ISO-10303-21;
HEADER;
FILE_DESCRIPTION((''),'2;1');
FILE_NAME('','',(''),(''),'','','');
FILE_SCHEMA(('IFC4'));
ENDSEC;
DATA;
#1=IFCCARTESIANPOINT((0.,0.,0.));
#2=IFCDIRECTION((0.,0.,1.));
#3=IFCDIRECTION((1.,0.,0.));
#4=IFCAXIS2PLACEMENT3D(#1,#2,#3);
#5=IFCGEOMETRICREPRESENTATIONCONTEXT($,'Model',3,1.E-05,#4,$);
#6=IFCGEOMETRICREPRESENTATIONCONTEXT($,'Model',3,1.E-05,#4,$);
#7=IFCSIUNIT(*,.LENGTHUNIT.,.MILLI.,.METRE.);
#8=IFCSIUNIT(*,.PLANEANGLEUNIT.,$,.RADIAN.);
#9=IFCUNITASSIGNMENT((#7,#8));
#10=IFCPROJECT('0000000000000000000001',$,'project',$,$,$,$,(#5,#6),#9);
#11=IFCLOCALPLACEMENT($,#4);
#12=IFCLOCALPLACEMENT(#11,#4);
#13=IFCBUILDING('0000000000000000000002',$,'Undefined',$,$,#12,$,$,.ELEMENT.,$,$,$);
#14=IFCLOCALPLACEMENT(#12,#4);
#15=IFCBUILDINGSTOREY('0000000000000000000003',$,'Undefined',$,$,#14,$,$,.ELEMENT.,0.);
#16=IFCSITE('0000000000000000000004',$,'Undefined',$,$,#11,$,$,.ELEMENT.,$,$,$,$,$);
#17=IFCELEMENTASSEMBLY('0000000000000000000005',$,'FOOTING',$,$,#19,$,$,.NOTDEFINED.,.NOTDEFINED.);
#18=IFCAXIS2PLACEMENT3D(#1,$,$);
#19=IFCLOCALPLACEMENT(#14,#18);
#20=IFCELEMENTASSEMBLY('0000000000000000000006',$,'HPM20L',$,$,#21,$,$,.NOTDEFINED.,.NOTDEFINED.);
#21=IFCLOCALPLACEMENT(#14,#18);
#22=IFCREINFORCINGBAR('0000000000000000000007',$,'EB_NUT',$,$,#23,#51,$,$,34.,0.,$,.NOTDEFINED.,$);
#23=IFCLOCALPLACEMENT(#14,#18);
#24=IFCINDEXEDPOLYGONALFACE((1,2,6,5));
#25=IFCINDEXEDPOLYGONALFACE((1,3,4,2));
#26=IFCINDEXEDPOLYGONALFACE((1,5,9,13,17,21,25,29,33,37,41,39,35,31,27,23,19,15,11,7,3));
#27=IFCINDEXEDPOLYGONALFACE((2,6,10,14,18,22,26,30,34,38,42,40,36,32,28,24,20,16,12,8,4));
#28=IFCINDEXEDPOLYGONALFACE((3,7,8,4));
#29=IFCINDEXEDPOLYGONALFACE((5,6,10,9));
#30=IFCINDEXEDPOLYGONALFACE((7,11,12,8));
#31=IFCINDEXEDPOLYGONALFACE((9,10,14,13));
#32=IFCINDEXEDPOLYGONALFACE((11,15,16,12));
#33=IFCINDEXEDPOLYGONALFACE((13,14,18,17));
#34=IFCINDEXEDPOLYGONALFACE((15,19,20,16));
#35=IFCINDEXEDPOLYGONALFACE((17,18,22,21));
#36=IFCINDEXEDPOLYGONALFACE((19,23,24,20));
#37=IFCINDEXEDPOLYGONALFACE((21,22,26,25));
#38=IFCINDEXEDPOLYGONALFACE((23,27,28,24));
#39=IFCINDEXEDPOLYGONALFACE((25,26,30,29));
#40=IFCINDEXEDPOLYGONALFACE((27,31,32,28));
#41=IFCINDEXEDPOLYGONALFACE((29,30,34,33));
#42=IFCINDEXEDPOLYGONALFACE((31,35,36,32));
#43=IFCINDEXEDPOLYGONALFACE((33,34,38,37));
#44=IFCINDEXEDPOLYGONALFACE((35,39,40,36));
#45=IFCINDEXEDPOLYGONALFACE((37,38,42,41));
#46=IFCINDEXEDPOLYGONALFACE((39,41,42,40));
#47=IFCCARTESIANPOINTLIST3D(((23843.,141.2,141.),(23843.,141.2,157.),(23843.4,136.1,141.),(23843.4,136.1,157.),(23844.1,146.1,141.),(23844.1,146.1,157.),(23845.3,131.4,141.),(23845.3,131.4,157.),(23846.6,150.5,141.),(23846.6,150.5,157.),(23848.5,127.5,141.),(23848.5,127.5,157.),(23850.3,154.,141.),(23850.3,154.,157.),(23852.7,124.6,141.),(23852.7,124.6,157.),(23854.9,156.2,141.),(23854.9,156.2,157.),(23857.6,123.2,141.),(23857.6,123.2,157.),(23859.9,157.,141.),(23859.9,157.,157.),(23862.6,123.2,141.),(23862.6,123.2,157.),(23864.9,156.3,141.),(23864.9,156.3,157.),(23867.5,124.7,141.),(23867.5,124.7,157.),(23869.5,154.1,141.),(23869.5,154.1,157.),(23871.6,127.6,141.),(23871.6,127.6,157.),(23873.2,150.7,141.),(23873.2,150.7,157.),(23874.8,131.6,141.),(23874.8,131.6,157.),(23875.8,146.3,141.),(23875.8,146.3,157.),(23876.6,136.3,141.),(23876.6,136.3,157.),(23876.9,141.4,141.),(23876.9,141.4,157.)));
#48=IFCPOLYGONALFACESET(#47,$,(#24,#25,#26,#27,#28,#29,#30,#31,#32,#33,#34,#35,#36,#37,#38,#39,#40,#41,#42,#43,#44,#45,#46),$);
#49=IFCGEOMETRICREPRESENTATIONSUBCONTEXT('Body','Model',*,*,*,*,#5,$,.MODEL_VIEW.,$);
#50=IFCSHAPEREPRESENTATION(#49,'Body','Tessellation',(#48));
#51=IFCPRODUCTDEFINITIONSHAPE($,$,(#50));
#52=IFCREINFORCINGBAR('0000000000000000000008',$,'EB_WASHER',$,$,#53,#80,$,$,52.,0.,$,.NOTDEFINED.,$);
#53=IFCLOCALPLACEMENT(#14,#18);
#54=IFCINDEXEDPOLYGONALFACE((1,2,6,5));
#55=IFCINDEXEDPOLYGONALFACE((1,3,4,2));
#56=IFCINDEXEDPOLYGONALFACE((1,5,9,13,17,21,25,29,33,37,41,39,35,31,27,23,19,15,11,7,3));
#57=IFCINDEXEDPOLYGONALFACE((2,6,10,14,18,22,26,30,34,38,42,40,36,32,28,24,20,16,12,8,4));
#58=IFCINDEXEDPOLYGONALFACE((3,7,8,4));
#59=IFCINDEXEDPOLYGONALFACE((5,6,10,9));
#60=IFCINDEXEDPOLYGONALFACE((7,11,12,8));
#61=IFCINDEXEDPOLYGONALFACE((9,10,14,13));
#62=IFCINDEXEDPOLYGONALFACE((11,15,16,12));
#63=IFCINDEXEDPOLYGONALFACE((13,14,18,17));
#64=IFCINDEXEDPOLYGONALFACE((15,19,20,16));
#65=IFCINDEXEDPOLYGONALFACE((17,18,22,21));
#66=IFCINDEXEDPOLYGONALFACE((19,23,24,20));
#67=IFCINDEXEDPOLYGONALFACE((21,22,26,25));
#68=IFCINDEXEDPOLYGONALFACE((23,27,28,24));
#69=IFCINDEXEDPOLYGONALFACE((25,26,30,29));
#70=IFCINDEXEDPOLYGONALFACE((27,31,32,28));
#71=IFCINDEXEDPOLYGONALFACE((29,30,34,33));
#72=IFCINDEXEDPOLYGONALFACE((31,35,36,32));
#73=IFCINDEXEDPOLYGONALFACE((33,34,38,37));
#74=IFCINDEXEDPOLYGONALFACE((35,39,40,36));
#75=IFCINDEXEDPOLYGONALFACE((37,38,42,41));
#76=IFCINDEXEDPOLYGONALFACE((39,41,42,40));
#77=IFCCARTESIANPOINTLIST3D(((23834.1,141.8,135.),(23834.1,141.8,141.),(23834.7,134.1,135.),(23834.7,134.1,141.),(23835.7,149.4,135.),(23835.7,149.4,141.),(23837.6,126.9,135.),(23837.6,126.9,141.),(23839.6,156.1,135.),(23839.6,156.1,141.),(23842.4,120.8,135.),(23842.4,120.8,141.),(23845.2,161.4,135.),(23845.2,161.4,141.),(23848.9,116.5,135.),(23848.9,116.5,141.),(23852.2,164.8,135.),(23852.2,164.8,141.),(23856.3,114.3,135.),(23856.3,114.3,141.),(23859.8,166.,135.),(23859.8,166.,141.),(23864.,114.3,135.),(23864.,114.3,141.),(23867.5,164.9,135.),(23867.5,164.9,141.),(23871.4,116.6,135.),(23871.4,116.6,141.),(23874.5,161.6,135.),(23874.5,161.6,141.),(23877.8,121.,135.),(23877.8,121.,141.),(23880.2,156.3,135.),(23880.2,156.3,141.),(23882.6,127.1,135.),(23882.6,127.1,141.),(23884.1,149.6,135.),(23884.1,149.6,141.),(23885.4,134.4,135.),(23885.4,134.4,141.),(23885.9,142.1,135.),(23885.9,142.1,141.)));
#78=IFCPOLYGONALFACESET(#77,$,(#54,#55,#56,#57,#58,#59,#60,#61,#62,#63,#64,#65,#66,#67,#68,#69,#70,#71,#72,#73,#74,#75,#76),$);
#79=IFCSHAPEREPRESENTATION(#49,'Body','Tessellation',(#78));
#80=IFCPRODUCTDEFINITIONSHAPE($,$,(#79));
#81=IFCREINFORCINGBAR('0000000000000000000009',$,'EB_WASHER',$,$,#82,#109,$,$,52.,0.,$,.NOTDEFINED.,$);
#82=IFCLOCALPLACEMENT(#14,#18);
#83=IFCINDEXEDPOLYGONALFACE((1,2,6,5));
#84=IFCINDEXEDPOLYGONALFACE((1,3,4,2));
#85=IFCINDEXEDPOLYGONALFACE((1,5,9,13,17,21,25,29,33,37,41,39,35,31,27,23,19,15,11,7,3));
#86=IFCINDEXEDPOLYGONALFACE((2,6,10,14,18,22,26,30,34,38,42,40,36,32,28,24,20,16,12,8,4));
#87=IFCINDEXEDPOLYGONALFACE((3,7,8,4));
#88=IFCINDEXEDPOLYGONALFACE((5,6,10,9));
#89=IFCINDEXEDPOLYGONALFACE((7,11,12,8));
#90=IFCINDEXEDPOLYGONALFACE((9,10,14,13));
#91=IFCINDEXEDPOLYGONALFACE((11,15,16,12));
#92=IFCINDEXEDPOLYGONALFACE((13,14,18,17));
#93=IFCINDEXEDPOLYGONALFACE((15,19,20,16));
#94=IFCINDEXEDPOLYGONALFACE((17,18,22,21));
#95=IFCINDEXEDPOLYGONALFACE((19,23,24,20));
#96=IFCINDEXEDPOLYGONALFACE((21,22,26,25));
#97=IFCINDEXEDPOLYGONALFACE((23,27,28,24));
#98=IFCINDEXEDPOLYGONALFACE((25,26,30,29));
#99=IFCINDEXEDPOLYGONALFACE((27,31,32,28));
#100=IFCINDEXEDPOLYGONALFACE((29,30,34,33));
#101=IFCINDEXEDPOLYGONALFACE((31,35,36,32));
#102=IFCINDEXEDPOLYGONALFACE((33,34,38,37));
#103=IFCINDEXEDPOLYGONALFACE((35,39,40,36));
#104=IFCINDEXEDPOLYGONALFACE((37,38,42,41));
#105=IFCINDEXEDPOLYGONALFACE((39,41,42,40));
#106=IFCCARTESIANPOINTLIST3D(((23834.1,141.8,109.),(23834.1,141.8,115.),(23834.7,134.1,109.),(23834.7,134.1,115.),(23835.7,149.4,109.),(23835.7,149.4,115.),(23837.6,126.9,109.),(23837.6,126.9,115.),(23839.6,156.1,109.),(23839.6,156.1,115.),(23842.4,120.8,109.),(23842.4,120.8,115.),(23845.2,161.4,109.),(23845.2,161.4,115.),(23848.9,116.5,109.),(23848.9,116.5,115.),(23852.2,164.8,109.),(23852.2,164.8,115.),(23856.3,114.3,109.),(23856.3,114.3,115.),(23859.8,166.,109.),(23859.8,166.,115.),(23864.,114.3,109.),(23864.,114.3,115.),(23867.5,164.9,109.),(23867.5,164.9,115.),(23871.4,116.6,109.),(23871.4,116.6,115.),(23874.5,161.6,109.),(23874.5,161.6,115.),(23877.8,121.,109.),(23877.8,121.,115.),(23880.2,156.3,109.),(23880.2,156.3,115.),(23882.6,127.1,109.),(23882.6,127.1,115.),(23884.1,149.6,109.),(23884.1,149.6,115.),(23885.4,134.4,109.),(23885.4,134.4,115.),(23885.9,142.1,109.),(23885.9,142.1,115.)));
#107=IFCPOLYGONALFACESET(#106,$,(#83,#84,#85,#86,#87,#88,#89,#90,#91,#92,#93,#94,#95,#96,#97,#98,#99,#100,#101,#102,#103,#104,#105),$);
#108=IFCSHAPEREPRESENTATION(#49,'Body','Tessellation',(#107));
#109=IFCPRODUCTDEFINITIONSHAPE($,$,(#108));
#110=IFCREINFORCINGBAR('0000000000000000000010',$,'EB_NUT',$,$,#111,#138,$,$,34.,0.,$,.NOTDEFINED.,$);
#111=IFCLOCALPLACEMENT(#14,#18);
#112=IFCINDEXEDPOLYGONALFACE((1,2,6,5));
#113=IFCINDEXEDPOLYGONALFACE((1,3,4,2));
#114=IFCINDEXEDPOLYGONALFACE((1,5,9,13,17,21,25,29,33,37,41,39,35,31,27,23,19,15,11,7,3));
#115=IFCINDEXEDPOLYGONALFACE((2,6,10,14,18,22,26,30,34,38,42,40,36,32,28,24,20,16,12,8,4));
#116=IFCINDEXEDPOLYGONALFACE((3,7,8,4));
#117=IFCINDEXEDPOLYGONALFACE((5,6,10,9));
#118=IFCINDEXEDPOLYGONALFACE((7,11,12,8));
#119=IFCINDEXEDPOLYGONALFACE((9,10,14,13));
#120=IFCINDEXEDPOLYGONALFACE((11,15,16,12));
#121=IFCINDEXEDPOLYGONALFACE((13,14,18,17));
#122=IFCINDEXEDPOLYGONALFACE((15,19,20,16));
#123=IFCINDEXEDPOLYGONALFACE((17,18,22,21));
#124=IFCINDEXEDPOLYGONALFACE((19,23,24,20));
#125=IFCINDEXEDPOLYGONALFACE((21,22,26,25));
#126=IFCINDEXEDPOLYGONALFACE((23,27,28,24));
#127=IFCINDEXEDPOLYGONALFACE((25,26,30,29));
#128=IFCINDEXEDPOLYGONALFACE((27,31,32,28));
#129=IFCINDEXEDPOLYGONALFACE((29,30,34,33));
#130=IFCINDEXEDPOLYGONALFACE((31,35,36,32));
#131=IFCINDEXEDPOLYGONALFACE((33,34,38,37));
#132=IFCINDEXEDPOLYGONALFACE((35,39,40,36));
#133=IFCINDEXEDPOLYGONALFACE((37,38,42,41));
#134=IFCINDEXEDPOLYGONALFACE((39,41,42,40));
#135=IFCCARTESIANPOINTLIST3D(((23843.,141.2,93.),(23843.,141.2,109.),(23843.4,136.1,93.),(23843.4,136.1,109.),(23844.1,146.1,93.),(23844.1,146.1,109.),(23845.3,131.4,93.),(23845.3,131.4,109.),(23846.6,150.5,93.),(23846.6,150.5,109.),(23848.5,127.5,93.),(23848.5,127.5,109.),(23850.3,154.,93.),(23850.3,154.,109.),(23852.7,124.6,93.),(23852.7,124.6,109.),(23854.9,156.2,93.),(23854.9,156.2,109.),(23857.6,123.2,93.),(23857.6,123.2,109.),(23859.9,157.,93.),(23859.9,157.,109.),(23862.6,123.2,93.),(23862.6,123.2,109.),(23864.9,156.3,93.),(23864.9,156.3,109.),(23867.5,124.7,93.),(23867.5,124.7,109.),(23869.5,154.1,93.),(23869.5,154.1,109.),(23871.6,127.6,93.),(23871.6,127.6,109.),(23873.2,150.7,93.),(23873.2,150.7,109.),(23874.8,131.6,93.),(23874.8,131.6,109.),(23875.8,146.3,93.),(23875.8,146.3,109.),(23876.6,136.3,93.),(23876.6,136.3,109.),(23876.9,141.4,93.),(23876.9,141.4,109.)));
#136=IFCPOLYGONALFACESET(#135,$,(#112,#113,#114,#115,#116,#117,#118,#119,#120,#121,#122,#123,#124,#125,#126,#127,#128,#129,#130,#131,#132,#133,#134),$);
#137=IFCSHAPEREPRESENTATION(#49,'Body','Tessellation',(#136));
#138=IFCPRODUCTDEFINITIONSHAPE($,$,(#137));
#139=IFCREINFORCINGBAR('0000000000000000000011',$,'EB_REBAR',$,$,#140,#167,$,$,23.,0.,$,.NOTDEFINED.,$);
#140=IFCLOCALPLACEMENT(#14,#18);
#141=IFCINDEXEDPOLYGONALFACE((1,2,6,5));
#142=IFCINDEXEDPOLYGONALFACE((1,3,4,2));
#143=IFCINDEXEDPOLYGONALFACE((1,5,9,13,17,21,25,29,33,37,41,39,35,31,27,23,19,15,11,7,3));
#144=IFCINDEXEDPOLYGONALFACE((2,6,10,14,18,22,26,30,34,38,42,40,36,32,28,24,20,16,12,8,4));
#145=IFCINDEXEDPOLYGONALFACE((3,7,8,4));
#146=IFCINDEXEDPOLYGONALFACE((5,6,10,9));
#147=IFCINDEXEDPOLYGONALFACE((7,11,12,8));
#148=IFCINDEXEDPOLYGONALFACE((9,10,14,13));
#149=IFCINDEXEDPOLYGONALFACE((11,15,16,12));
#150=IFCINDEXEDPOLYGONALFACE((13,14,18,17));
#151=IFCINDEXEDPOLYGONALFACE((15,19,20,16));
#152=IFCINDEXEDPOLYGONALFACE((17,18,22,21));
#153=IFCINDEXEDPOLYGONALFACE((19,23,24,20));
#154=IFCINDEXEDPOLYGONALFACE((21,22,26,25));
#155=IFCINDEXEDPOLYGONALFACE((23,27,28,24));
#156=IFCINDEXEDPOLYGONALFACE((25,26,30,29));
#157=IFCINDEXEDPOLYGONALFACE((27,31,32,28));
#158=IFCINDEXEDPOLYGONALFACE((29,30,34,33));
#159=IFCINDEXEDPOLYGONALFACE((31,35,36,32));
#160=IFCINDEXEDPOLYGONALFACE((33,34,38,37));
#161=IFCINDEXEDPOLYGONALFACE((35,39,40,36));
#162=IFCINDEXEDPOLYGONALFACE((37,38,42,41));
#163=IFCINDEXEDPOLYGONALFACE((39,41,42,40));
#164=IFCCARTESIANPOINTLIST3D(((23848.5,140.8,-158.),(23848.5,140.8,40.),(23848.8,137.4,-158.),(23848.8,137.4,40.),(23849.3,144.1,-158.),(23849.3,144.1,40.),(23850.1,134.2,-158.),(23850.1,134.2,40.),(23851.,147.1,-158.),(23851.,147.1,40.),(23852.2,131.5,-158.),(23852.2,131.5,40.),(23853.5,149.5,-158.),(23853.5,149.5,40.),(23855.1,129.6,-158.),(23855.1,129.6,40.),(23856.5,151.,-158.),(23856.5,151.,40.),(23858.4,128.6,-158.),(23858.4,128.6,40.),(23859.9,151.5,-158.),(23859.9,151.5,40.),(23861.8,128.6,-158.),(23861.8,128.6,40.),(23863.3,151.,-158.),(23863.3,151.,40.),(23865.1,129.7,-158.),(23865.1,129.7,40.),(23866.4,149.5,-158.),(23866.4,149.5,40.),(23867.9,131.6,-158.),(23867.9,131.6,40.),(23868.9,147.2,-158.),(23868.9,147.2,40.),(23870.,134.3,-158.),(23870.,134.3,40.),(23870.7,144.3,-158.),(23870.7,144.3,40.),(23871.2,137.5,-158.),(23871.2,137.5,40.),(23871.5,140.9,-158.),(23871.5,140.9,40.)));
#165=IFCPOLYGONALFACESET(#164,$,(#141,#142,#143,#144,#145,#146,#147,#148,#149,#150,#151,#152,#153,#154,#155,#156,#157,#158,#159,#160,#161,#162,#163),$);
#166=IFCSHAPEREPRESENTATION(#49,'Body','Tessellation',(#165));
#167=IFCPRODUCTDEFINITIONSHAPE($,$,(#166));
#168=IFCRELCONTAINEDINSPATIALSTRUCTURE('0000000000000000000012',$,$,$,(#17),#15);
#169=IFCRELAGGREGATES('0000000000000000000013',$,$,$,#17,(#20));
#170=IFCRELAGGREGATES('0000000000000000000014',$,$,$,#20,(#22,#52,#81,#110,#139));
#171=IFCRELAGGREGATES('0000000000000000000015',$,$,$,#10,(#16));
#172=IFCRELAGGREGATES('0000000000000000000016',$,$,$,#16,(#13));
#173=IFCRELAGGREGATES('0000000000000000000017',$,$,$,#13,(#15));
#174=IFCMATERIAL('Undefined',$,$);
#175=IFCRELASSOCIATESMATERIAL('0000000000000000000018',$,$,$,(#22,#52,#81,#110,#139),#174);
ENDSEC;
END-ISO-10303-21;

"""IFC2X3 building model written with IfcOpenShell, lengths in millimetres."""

from ifc_helpers import new_model, entity, si_unit, frame, origin_with_axes, place, context, subcontext, project, spatial, source, transform, mapped, material, element, aggregate, save


model = new_model("IFC2X3")

# Units and contexts
model_context_1 = context("Model", 3, precision=1e-05, world=origin_with_axes())
model_context_2 = context("Model", 3, precision=1e-05, world=origin_with_axes())
body_context = subcontext(model_context_1, "Body", "Model", "MODEL_VIEW")
ifc_project = project(units=[si_unit("LENGTHUNIT", "METRE", prefix="MILLI"), si_unit("PLANEANGLEUNIT", "RADIAN")], contexts=[model_context_1, model_context_2])

# Site, building, storey
site_placement = place(None, origin_with_axes())
site = spatial("IfcSite", under=ifc_project, at=site_placement, Name="Undefined", CompositionType="ELEMENT")
building_placement = place(site_placement, origin_with_axes())
building = spatial("IfcBuilding", under=site, at=building_placement, Name="Undefined", CompositionType="ELEMENT")
storey_placement = place(building_placement, origin_with_axes())
storey = spatial("IfcBuildingStorey", under=building, at=storey_placement, Name="Undefined", CompositionType="ELEMENT", Elevation=0.0)

# Element assembly
assembly_1_placement = place(storey_placement, origin_with_axes())
assembly_1 = element("IfcElementAssembly", 1, at=assembly_1_placement, inside=storey, Name="FOOTING", AssemblyPlace="NOTDEFINED", PredefinedType="NOTDEFINED")

# Shared definitions
ifc_material_1 = material(Name="Undefined")

# Element assembly
assembly_2_placement = place(assembly_1_placement, origin_with_axes())
assembly_2 = element("IfcElementAssembly", 2, at=assembly_2_placement, Name="HPM20L", AssemblyPlace="NOTDEFINED", PredefinedType="NOTDEFINED")
aggregate(assembly_1, [assembly_2])

# Reinforcing bars
shared_shape_1 = source(origin_with_axes(), body_context, "Body", "AdvancedSweptSolid", [
    entity("IfcSweptDiskSolid", entity("IfcTrimmedCurve", entity("IfcLine", entity("IfcCartesianPoint", [0.0, 0.0, 0.0]), entity("IfcVector", entity("IfcDirection", [1.0, 0.0, 0.0]), 1.0)), [entity("IfcParameterValue", 0.0)], [entity("IfcParameterValue", 16.0)], True, "PARAMETER"), 17.0, None, 0.0, 16.0),
])
reinforcing_bar_1_placement = place(assembly_2_placement, frame((23860.0, 140.0, 157.0), z_axis=(-0.005867, 0.999983, 0.0), x_axis=(0.0, 0.0, -1.0)))
reinforcing_bar_1 = element("IfcReinforcingBar", 3, at=reinforcing_bar_1_placement, material=ifc_material_1, Name="EB_NUT", BarRole="NOTDEFINED", CrossSectionArea=0.0, NominalDiameter=34.0, context=body_context, shape_type="MappedRepresentation", body=[
    mapped(shared_shape_1, transform((0.0, 0.0, 0.0))),
])
shared_shape_2 = source(origin_with_axes(), body_context, "Body", "AdvancedSweptSolid", [
    entity("IfcSweptDiskSolid", entity("IfcTrimmedCurve", entity("IfcLine", entity("IfcCartesianPoint", [0.0, 0.0, 0.0]), entity("IfcVector", entity("IfcDirection", [1.0, 0.0, 0.0]), 1.0)), [entity("IfcParameterValue", 0.0)], [entity("IfcParameterValue", 6.0)], True, "PARAMETER"), 26.0, None, 0.0, 6.0),
])
reinforcing_bar_2_placement = place(assembly_2_placement, frame((23860.0, 140.0, 141.0), z_axis=(-0.005867, 0.999983, 0.0), x_axis=(0.0, 0.0, -1.0)))
reinforcing_bar_2 = element("IfcReinforcingBar", 4, at=reinforcing_bar_2_placement, material=ifc_material_1, Name="EB_WASHER", BarRole="NOTDEFINED", CrossSectionArea=0.0, NominalDiameter=52.0, context=body_context, shape_type="MappedRepresentation", body=[
    mapped(shared_shape_2, transform((0.0, 0.0, 0.0))),
])
shared_shape_3 = source(origin_with_axes(), body_context, "Body", "AdvancedSweptSolid", [
    entity("IfcSweptDiskSolid", entity("IfcTrimmedCurve", entity("IfcLine", entity("IfcCartesianPoint", [0.0, 0.0, 0.0]), entity("IfcVector", entity("IfcDirection", [1.0, 0.0, 0.0]), 1.0)), [entity("IfcParameterValue", 0.0)], [entity("IfcParameterValue", 6.0)], True, "PARAMETER"), 26.0, None, 0.0, 6.0),
])
reinforcing_bar_3_placement = place(assembly_2_placement, frame((23860.0, 140.0, 115.0), z_axis=(-0.005867, 0.999983, 0.0), x_axis=(0.0, 0.0, -1.0)))
reinforcing_bar_3 = element("IfcReinforcingBar", 5, at=reinforcing_bar_3_placement, material=ifc_material_1, Name="EB_WASHER", BarRole="NOTDEFINED", CrossSectionArea=0.0, NominalDiameter=52.0, context=body_context, shape_type="MappedRepresentation", body=[
    mapped(shared_shape_3, transform((0.0, 0.0, 0.0))),
])
shared_shape_4 = source(origin_with_axes(), body_context, "Body", "AdvancedSweptSolid", [
    entity("IfcSweptDiskSolid", entity("IfcTrimmedCurve", entity("IfcLine", entity("IfcCartesianPoint", [0.0, 0.0, 0.0]), entity("IfcVector", entity("IfcDirection", [1.0, 0.0, 0.0]), 1.0)), [entity("IfcParameterValue", 0.0)], [entity("IfcParameterValue", 16.0)], True, "PARAMETER"), 17.0, None, 0.0, 16.0),
])
reinforcing_bar_4_placement = place(assembly_2_placement, frame((23860.0, 140.0, 109.0), z_axis=(-0.005867, 0.999983, 0.0), x_axis=(0.0, 0.0, -1.0)))
reinforcing_bar_4 = element("IfcReinforcingBar", 6, at=reinforcing_bar_4_placement, material=ifc_material_1, Name="EB_NUT", BarRole="NOTDEFINED", CrossSectionArea=0.0, NominalDiameter=34.0, context=body_context, shape_type="MappedRepresentation", body=[
    mapped(shared_shape_4, transform((0.0, 0.0, 0.0))),
])
shared_shape_5 = source(origin_with_axes(), body_context, "Body", "AdvancedSweptSolid", [
    entity("IfcSweptDiskSolid", entity("IfcTrimmedCurve", entity("IfcLine", entity("IfcCartesianPoint", [0.0, 0.0, 0.0]), entity("IfcVector", entity("IfcDirection", [1.0, 0.0, 0.0]), 1.0)), [entity("IfcParameterValue", 0.0)], [entity("IfcParameterValue", 198.0)], True, "PARAMETER"), 11.5, None, 0.0, 198.0),
])
reinforcing_bar_5_placement = place(assembly_2_placement, frame((23860.0, 140.0, 40.0), z_axis=(-0.005867, 0.999983, 0.0), x_axis=(0.0, 0.0, -1.0)))
reinforcing_bar_5 = element("IfcReinforcingBar", 7, at=reinforcing_bar_5_placement, material=ifc_material_1, Name="EB_REBAR", BarRole="NOTDEFINED", CrossSectionArea=0.0, NominalDiameter=23.0, context=body_context, shape_type="MappedRepresentation", body=[
    mapped(shared_shape_5, transform((0.0, 0.0, 0.0))),
])
aggregate(assembly_2, [reinforcing_bar_1, reinforcing_bar_2, reinforcing_bar_3, reinforcing_bar_4, reinforcing_bar_5])

save(model, "model.ifc")
